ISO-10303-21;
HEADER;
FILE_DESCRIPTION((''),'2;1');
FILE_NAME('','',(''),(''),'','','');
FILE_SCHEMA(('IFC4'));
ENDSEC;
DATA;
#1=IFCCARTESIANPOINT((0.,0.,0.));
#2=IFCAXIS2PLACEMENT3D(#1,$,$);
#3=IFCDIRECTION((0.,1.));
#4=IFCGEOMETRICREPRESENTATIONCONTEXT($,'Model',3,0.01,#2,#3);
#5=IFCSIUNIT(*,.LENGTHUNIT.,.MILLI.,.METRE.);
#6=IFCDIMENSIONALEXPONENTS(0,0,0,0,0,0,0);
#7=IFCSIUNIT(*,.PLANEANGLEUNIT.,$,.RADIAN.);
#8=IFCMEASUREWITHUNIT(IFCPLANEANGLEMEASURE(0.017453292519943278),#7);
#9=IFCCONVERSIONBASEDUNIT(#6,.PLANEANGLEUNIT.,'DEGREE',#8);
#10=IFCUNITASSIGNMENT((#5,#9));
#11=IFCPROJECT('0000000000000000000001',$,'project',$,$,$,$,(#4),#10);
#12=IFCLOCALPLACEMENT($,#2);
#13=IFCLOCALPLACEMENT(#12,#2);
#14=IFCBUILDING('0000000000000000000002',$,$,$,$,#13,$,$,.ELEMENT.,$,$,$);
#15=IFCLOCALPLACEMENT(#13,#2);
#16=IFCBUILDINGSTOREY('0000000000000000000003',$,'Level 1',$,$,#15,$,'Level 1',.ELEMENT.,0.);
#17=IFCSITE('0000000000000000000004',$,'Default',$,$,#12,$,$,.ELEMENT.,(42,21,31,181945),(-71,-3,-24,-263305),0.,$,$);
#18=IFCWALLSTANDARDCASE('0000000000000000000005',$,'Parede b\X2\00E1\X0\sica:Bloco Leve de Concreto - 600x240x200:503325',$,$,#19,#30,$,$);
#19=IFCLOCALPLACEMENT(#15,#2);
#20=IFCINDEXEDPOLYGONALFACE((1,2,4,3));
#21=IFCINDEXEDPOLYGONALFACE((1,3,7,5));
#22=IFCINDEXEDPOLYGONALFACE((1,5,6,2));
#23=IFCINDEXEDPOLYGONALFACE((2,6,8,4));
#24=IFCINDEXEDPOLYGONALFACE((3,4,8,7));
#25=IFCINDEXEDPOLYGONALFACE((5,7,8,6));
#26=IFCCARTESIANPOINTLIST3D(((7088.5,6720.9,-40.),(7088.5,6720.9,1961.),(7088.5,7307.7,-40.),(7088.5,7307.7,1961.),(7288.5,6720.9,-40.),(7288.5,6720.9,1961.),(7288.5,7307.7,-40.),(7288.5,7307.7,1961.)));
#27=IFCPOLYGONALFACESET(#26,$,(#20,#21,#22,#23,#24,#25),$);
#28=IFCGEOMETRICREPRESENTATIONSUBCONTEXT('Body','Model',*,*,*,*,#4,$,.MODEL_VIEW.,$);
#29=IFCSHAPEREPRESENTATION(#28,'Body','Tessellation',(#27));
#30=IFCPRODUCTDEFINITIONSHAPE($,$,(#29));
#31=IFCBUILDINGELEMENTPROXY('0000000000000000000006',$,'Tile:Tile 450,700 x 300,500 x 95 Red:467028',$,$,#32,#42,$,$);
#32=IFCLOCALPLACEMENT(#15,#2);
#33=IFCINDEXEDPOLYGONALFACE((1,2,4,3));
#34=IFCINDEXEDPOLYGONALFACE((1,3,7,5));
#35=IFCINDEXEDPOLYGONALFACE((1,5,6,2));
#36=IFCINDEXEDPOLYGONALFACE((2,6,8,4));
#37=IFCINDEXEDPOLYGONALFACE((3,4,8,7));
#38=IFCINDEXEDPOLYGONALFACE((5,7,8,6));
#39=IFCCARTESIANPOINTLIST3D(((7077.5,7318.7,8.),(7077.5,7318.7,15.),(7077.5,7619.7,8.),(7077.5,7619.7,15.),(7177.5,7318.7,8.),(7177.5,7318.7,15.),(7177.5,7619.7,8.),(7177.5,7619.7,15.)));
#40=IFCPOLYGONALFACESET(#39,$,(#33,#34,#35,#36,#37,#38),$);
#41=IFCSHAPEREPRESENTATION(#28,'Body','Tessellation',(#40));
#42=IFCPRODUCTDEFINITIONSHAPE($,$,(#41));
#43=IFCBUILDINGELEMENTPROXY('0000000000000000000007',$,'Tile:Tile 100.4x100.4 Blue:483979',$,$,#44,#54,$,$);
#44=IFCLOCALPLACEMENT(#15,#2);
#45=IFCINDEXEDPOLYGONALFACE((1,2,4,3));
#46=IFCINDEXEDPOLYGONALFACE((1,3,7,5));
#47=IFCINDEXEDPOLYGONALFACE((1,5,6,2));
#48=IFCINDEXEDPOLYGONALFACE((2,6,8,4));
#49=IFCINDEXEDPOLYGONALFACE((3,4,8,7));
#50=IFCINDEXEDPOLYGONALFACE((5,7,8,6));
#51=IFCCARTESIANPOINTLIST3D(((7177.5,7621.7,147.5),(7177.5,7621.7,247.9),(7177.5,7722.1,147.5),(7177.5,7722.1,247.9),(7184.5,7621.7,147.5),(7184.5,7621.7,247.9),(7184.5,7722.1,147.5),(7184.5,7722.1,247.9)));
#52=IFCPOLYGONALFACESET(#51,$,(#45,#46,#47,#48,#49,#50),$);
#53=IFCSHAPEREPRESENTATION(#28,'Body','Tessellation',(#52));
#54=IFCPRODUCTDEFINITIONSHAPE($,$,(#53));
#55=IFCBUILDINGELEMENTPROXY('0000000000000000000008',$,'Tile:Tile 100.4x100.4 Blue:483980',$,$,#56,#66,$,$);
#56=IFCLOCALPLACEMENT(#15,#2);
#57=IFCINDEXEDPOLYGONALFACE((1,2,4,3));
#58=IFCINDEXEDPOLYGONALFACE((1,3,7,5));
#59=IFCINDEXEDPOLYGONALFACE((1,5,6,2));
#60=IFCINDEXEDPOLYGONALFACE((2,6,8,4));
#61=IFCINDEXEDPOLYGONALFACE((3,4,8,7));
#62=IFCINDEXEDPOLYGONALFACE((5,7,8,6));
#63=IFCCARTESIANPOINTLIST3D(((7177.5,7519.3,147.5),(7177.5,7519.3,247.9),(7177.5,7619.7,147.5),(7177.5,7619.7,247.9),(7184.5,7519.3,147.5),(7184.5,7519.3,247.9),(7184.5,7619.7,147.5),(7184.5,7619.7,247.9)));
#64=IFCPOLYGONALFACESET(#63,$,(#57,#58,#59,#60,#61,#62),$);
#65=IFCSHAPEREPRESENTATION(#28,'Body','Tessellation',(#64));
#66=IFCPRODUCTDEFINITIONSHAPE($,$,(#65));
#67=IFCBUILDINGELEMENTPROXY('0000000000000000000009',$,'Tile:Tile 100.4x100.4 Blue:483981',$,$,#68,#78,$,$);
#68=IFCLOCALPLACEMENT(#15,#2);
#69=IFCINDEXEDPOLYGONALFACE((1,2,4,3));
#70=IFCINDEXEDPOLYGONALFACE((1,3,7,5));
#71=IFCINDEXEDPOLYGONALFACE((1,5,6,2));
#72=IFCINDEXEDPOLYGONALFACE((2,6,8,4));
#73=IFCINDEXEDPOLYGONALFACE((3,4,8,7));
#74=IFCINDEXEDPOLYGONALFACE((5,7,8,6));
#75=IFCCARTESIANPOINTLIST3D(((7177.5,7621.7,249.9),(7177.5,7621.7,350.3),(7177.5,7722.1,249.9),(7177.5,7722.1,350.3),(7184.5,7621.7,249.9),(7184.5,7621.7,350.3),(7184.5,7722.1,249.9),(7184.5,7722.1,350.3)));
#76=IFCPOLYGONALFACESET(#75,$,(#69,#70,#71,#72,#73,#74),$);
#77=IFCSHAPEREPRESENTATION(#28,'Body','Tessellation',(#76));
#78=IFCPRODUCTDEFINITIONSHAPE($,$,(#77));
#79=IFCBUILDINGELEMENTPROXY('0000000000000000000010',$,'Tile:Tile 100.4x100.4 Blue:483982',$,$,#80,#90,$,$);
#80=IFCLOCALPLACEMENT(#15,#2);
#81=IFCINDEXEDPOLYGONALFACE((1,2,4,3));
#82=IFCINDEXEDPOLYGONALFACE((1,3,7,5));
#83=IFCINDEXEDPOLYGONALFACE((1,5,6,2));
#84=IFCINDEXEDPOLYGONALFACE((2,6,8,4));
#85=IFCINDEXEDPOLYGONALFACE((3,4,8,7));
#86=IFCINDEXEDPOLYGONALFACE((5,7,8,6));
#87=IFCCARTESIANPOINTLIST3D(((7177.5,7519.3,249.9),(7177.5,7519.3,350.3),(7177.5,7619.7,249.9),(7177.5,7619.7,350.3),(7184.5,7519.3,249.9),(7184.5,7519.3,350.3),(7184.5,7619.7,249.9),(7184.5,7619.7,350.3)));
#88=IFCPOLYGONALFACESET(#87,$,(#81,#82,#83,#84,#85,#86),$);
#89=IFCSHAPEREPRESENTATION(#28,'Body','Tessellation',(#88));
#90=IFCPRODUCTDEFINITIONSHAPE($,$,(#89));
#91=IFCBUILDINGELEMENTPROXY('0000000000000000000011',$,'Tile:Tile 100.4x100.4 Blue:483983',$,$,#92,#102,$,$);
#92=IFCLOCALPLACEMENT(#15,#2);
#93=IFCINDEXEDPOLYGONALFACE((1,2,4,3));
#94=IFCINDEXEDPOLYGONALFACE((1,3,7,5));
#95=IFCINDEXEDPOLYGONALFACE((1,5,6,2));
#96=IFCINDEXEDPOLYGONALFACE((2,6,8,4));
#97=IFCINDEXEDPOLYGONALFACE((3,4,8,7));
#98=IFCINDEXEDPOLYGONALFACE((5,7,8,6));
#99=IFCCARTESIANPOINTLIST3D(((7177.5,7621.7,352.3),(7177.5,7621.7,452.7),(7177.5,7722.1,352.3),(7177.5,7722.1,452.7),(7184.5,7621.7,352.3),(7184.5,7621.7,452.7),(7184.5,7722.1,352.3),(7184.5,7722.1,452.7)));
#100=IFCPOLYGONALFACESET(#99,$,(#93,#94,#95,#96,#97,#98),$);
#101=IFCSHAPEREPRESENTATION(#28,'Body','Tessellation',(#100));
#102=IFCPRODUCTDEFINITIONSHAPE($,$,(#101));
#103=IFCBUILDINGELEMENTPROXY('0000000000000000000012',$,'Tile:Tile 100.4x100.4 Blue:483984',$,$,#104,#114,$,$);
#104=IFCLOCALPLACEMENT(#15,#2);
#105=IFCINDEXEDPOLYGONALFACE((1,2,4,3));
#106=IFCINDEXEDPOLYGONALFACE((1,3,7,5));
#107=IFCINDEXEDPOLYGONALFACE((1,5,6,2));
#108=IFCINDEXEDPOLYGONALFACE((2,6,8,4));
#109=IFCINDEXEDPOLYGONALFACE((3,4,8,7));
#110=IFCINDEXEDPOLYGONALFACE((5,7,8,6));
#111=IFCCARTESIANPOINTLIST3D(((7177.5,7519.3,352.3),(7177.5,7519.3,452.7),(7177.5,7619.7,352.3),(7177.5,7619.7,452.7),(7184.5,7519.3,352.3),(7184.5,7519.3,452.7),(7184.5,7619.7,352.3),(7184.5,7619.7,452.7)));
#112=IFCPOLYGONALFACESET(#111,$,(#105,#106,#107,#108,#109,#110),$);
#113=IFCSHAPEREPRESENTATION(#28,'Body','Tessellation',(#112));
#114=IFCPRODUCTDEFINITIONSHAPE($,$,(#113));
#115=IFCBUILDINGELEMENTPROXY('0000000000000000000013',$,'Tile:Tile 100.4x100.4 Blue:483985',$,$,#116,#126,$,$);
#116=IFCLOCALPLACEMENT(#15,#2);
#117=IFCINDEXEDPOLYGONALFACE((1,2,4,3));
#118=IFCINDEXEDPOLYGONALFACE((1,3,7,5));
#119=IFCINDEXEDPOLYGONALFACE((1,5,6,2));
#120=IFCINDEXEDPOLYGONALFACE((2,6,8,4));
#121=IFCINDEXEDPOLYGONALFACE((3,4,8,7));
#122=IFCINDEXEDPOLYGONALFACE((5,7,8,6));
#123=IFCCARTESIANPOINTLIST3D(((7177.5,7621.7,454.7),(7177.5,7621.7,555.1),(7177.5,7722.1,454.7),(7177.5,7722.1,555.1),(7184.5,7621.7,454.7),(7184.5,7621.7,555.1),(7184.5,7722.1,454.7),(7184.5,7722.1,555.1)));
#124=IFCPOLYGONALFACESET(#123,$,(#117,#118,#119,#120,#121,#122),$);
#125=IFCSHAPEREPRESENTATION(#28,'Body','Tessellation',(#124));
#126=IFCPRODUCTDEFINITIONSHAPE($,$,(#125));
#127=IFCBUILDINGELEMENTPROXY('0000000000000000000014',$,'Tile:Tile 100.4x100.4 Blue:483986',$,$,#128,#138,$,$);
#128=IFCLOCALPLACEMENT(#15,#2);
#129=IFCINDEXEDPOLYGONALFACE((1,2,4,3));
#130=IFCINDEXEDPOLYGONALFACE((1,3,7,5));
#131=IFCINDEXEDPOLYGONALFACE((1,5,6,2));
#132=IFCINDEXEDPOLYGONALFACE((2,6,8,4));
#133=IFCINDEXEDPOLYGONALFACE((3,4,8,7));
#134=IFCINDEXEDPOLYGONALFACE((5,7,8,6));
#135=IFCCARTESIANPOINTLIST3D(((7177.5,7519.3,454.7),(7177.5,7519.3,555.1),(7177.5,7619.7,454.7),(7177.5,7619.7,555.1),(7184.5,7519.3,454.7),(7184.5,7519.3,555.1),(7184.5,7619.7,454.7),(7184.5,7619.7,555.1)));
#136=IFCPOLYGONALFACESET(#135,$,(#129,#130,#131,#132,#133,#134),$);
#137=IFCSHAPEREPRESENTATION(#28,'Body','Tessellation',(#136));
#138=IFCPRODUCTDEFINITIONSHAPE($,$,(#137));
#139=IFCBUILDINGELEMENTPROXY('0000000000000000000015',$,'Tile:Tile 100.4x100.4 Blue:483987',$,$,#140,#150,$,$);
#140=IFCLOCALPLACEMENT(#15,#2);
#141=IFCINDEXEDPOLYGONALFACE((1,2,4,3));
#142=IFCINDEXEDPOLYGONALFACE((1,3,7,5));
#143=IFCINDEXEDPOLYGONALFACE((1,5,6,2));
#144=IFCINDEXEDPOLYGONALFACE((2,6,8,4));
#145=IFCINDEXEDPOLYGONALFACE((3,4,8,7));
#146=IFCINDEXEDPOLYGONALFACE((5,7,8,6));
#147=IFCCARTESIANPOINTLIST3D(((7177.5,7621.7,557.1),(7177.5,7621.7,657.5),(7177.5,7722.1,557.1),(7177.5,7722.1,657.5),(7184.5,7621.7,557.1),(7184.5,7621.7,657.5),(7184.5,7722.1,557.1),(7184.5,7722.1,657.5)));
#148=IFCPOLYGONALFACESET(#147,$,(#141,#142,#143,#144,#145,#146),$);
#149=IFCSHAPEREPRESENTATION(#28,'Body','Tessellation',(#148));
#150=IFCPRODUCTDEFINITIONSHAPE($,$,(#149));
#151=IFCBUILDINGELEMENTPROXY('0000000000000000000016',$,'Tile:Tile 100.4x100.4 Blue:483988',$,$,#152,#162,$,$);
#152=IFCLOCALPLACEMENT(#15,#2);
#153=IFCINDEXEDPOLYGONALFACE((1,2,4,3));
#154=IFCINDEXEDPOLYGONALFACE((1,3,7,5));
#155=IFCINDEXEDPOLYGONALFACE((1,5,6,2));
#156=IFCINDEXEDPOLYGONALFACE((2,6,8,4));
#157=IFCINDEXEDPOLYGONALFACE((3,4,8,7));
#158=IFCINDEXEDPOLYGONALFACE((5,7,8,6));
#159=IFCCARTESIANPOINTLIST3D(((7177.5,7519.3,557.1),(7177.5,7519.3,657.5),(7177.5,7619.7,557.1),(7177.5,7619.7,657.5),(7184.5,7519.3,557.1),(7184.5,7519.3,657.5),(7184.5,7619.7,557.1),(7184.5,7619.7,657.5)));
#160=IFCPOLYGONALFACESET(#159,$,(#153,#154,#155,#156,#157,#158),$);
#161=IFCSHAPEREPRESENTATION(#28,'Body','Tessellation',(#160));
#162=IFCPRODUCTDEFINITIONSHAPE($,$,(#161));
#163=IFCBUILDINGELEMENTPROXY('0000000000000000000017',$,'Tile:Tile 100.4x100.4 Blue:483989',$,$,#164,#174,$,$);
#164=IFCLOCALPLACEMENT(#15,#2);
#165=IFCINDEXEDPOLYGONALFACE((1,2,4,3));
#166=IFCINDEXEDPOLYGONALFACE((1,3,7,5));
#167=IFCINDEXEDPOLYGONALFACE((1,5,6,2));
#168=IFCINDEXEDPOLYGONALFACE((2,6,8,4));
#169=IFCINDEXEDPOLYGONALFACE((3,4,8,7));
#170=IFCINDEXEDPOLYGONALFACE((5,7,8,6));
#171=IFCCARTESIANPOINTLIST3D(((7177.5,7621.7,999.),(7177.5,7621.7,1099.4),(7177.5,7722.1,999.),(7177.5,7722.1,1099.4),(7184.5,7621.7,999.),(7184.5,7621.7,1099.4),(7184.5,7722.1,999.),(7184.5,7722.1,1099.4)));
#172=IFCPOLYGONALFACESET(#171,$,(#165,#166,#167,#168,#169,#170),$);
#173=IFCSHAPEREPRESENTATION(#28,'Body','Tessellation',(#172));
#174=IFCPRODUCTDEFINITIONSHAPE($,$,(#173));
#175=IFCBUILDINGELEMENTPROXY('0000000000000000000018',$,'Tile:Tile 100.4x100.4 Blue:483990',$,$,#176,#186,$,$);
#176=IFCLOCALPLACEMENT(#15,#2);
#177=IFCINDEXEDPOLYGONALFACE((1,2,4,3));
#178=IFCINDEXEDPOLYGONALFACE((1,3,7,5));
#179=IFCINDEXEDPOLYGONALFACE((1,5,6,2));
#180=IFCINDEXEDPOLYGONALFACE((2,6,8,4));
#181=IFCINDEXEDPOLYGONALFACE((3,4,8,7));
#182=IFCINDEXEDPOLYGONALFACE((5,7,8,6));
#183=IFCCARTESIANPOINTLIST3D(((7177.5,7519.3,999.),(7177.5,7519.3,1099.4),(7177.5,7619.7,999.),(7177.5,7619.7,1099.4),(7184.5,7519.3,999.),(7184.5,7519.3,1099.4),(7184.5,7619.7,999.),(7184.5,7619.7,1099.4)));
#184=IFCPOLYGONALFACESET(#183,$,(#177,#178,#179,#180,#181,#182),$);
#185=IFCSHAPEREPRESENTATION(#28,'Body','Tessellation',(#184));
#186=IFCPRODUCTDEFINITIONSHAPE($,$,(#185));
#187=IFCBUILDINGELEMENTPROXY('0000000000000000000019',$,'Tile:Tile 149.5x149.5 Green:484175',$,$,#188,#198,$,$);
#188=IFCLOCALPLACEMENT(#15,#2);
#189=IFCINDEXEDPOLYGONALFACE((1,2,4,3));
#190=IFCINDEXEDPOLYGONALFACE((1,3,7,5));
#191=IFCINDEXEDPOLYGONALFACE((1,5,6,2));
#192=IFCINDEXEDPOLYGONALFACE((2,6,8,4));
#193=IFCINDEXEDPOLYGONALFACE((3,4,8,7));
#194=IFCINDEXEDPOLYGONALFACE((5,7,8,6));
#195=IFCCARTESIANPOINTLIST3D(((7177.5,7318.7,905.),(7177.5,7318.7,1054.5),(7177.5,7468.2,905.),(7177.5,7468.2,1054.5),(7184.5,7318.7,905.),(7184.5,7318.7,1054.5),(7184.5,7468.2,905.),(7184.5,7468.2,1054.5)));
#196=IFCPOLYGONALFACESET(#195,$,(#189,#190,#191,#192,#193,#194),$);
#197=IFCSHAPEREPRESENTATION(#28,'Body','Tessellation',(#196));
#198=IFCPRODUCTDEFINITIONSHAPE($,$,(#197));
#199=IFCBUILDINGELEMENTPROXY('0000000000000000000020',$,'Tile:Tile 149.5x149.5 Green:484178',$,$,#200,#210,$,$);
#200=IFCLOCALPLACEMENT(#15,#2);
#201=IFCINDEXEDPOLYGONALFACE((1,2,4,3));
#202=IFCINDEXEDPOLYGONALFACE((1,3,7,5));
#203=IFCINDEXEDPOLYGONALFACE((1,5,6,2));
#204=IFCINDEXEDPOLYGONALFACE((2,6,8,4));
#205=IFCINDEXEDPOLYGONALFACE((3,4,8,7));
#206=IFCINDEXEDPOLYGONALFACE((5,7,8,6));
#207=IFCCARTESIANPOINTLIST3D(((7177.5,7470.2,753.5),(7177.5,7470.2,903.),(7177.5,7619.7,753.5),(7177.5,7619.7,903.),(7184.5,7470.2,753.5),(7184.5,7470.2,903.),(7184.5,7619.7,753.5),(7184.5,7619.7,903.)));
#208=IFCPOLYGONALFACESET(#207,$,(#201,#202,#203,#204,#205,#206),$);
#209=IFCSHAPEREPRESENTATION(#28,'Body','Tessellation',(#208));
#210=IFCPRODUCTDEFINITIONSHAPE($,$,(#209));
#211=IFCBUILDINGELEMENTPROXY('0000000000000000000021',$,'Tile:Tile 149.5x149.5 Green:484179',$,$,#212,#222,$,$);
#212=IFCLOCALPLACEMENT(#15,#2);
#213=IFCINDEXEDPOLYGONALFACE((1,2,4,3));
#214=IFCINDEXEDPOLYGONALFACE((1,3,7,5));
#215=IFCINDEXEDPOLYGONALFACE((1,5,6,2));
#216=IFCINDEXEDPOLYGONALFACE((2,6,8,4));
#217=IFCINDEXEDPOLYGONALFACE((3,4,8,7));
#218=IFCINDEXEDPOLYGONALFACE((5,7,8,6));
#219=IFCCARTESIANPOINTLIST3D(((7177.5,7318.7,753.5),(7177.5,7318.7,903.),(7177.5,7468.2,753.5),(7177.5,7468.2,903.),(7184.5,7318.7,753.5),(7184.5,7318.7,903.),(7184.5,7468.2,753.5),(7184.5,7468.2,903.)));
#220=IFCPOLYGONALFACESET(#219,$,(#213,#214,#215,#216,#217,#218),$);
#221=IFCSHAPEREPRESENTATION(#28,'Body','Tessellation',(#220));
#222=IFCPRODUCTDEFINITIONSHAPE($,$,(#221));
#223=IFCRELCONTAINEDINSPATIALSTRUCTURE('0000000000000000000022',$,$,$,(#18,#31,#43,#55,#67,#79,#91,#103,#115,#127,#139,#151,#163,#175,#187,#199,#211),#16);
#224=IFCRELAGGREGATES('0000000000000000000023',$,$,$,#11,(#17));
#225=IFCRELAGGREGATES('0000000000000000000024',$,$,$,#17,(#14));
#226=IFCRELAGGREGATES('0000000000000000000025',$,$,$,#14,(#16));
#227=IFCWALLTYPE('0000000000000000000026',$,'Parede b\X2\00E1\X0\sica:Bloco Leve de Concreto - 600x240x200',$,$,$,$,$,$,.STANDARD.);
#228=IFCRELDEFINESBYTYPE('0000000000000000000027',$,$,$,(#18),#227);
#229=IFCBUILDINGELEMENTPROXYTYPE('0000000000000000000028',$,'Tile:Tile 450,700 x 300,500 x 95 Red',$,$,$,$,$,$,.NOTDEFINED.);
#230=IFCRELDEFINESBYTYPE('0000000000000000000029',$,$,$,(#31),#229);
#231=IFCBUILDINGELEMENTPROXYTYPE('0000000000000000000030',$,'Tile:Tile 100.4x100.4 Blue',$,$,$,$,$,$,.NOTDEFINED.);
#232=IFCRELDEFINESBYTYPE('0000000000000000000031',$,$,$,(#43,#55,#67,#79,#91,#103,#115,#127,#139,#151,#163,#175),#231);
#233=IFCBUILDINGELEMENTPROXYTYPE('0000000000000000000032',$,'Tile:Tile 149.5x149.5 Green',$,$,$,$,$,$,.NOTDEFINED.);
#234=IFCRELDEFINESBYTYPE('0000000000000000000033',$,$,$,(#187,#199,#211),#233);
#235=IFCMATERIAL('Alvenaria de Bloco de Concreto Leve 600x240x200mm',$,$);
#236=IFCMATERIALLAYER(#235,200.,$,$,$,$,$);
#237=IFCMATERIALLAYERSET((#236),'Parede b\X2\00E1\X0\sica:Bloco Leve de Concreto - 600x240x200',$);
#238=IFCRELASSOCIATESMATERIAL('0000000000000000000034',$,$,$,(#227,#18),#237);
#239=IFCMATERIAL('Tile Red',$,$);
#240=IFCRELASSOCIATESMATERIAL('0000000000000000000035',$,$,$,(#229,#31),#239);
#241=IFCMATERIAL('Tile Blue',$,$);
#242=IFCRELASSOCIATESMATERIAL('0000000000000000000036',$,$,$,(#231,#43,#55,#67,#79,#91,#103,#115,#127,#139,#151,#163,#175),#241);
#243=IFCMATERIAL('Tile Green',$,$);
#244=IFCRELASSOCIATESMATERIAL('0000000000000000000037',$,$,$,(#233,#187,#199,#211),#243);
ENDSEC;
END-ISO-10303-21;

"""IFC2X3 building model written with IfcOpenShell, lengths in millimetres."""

from ifc_helpers import new_model, entity, si_unit, converted_unit, direction, frame, frame_2d, origin, origin_2d_with_axis, place, context, subcontext, project, spatial, rectangle, extrude, source, transform, mapped, material, layer, layer_set, layer_usage, type_object, type_shapes, element, save


model = new_model("IFC2X3")

# Units and contexts
model_context = context("Model", 3, precision=0.01, world=origin(), true_north=direction((0.0, 1.0)))
body_context = subcontext(model_context, "Body", "Model", "MODEL_VIEW")
ifc_project = project(units=[si_unit("LENGTHUNIT", "METRE", prefix="MILLI"), converted_unit("PLANEANGLEUNIT", "DEGREE", entity("IfcPlaneAngleMeasure", 0.017453292519943278), si_unit("PLANEANGLEUNIT", "RADIAN"), dimensions=[0, 0, 0, 0, 0, 0, 0])], contexts=[model_context])

# Site, building, storey
site_placement = place(None, origin())
site = spatial("IfcSite", under=ifc_project, at=site_placement, Name="Default", CompositionType="ELEMENT", RefLatitude=(42, 21, 31, 181945), RefLongitude=(-71, -3, -24, -263305), RefElevation=0.0)
building_placement = place(site_placement, origin())
building = spatial("IfcBuilding", under=site, at=building_placement, CompositionType="ELEMENT")
storey_placement = place(building_placement, origin())
storey = spatial("IfcBuildingStorey", under=building, at=storey_placement, Name="Level 1", LongName="Level 1", CompositionType="ELEMENT", Elevation=0.0)

# Wall
ifc_material_1 = material(Name="Alvenaria de Bloco de Concreto Leve 600x240x200mm")
ifc_layer = layer(ifc_material_1, 200.0)
ifc_layer_set = layer_set([ifc_layer], Name="Parede básica:Bloco Leve de Concreto - 600x240x200")
ifc_layer_usage = layer_usage(ifc_layer_set, "AXIS2", "NEGATIVE", 100.0)
wall_type = type_object("IfcWallType", Name="Parede básica:Bloco Leve de Concreto - 600x240x200", PredefinedType="STANDARD", material=ifc_layer_set)
wall_placement = place(storey_placement, frame((7188.5, 7307.7, -40.0), z_axis=(0.0, 0.0, 1.0), x_axis=(0.0, -1.0, 0.0)))
element("IfcWallStandardCase", 1, at=wall_placement, inside=storey, type_object=wall_type, material=ifc_layer_usage, Name="Parede básica:Bloco Leve de Concreto - 600x240x200:503325", context=body_context, shape_type="SweptSolid", body=[
    extrude(rectangle(XDim=586.8, YDim=200.0, at=frame_2d((293.4, 0.0), x_axis=(-1.0, 0.0))), origin(), (0.0, 0.0, 1.0), 2001.0),
])

# Building element proxies
ifc_material_2 = material(Name="Tile Red")
building_element_proxy_type_1 = type_object("IfcBuildingElementProxyType", Name="Tile:Tile 450,700 x 300,500 x 95 Red", PredefinedType="NOTDEFINED", material=ifc_material_2)
shared_shape_1 = source(origin(), body_context, "Body", "SweptSolid", [
    extrude(rectangle(XDim=100.0, YDim=301.0, at=frame_2d((0.0, 0.0), x_axis=(1.0, 0.0))), frame((-50.0, -150.5, 0.0), z_axis=(0.0, 0.0, 1.0), x_axis=(-1.0, 0.0, 0.0)), (0.0, 0.0, 1.0), 7.0),
])
type_shapes(building_element_proxy_type_1, [shared_shape_1])
proxy_placement = place(storey_placement, frame((7177.5, 7619.7, 8.0)))
element("IfcBuildingElementProxy", 2, at=proxy_placement, inside=storey, type_object=building_element_proxy_type_1, material=ifc_material_2, Name="Tile:Tile 450,700 x 300,500 x 95 Red:467028", context=body_context, shape_type="MappedRepresentation", body=[
    mapped(shared_shape_1, transform((0.0, 0.0, 0.0), scale=1.0)),
])
ifc_material_3 = material(Name="Tile Blue")
building_element_proxy_type_2 = type_object("IfcBuildingElementProxyType", Name="Tile:Tile 100.4x100.4 Blue", PredefinedType="NOTDEFINED", material=ifc_material_3)
shared_shape_2 = source(origin(), body_context, "Body", "SweptSolid", [
    extrude(rectangle(XDim=100.4, YDim=100.4, at=origin_2d_with_axis()), frame((-50.2, -50.2, 0.0), z_axis=(0.0, 0.0, 1.0), x_axis=(0.0, -1.0, 0.0)), (0.0, 0.0, 1.0), 7.0),
])
type_shapes(building_element_proxy_type_2, [shared_shape_2])
for number, where, z_axis, x_axis, name in (
    (3, (7184.5, 7722.1, 147.5), (-1.0, 0.0, 0.0), (0.0, 1.0, 0.0), "Tile:Tile 100.4x100.4 Blue:483979"),
    (4, (7184.5, 7619.7, 147.5), (-1.0, 0.0, 0.0), (0.0, 1.0, 0.0), "Tile:Tile 100.4x100.4 Blue:483980"),
    (5, (7184.5, 7722.1, 249.9), (-1.0, 0.0, 0.0), (0.0, 1.0, 0.0), "Tile:Tile 100.4x100.4 Blue:483981"),
    (6, (7184.5, 7619.7, 249.9), (-1.0, 0.0, 0.0), (0.0, 1.0, 0.0), "Tile:Tile 100.4x100.4 Blue:483982"),
    (7, (7184.5, 7722.1, 352.3), (-1.0, 0.0, 0.0), (0.0, 1.0, 0.0), "Tile:Tile 100.4x100.4 Blue:483983"),
    (8, (7184.5, 7619.7, 352.3), (-1.0, 0.0, 0.0), (0.0, 1.0, 0.0), "Tile:Tile 100.4x100.4 Blue:483984"),
    (9, (7184.5, 7722.1, 454.7), (-1.0, 0.0, 0.0), (0.0, 1.0, 0.0), "Tile:Tile 100.4x100.4 Blue:483985"),
    (10, (7184.5, 7619.7, 454.7), (-1.0, 0.0, 0.0), (0.0, 1.0, 0.0), "Tile:Tile 100.4x100.4 Blue:483986"),
    (11, (7184.5, 7722.1, 557.1), (-1.0, 0.0, 0.0), (0.0, 1.0, 0.0), "Tile:Tile 100.4x100.4 Blue:483987"),
    (12, (7184.5, 7619.7, 557.1), (-1.0, 0.0, 0.0), (0.0, 1.0, 0.0), "Tile:Tile 100.4x100.4 Blue:483988"),
    (13, (7184.5, 7722.1, 999.0), (-1.0, 0.0, 0.0), (0.0, 1.0, 0.0), "Tile:Tile 100.4x100.4 Blue:483989"),
    (14, (7184.5, 7619.7, 999.0), (-1.0, 0.0, 0.0), (0.0, 1.0, 0.0), "Tile:Tile 100.4x100.4 Blue:483990"),
):
    element("IfcBuildingElementProxy", number, at=place(storey_placement, frame(where, z_axis=z_axis, x_axis=x_axis)), inside=storey, type_object=building_element_proxy_type_2, material=ifc_material_3, Name=name, context=body_context, shape_type="MappedRepresentation", body=[
        mapped(shared_shape_2, transform((0.0, 0.0, 0.0), scale=1.0)),
    ])
ifc_material_4 = material(Name="Tile Green")
building_element_proxy_type_3 = type_object("IfcBuildingElementProxyType", Name="Tile:Tile 149.5x149.5 Green", PredefinedType="NOTDEFINED", material=ifc_material_4)
shared_shape_3 = source(origin(), body_context, "Body", "SweptSolid", [
    extrude(rectangle(XDim=149.5, YDim=149.5, at=origin_2d_with_axis()), frame((-74.7, -74.8, 0.0), z_axis=(0.0, 0.0, 1.0), x_axis=(0.0, -1.0, 0.0)), (0.0, 0.0, 1.0), 7.0),
])
type_shapes(building_element_proxy_type_3, [shared_shape_3])
for number, where, z_axis, x_axis, name in (
    (15, (7184.5, 7468.2, 1054.5), (-1.0, 0.0, 0.0), (0.0, 0.0, 1.0), "Tile:Tile 149.5x149.5 Green:484175"),
    (16, (7184.5, 7619.7, 903.0), (-1.0, 0.0, 0.0), (0.0, 0.0, 1.0), "Tile:Tile 149.5x149.5 Green:484178"),
    (17, (7184.5, 7468.2, 903.0), (-1.0, 0.0, 0.0), (0.0, 0.0, 1.0), "Tile:Tile 149.5x149.5 Green:484179"),
):
    element("IfcBuildingElementProxy", number, at=place(storey_placement, frame(where, z_axis=z_axis, x_axis=x_axis)), inside=storey, type_object=building_element_proxy_type_3, material=ifc_material_4, Name=name, context=body_context, shape_type="MappedRepresentation", body=[
        mapped(shared_shape_3, transform((0.0, 0.0, 0.0), scale=1.0)),
    ])

save(model, "model.ifc")
